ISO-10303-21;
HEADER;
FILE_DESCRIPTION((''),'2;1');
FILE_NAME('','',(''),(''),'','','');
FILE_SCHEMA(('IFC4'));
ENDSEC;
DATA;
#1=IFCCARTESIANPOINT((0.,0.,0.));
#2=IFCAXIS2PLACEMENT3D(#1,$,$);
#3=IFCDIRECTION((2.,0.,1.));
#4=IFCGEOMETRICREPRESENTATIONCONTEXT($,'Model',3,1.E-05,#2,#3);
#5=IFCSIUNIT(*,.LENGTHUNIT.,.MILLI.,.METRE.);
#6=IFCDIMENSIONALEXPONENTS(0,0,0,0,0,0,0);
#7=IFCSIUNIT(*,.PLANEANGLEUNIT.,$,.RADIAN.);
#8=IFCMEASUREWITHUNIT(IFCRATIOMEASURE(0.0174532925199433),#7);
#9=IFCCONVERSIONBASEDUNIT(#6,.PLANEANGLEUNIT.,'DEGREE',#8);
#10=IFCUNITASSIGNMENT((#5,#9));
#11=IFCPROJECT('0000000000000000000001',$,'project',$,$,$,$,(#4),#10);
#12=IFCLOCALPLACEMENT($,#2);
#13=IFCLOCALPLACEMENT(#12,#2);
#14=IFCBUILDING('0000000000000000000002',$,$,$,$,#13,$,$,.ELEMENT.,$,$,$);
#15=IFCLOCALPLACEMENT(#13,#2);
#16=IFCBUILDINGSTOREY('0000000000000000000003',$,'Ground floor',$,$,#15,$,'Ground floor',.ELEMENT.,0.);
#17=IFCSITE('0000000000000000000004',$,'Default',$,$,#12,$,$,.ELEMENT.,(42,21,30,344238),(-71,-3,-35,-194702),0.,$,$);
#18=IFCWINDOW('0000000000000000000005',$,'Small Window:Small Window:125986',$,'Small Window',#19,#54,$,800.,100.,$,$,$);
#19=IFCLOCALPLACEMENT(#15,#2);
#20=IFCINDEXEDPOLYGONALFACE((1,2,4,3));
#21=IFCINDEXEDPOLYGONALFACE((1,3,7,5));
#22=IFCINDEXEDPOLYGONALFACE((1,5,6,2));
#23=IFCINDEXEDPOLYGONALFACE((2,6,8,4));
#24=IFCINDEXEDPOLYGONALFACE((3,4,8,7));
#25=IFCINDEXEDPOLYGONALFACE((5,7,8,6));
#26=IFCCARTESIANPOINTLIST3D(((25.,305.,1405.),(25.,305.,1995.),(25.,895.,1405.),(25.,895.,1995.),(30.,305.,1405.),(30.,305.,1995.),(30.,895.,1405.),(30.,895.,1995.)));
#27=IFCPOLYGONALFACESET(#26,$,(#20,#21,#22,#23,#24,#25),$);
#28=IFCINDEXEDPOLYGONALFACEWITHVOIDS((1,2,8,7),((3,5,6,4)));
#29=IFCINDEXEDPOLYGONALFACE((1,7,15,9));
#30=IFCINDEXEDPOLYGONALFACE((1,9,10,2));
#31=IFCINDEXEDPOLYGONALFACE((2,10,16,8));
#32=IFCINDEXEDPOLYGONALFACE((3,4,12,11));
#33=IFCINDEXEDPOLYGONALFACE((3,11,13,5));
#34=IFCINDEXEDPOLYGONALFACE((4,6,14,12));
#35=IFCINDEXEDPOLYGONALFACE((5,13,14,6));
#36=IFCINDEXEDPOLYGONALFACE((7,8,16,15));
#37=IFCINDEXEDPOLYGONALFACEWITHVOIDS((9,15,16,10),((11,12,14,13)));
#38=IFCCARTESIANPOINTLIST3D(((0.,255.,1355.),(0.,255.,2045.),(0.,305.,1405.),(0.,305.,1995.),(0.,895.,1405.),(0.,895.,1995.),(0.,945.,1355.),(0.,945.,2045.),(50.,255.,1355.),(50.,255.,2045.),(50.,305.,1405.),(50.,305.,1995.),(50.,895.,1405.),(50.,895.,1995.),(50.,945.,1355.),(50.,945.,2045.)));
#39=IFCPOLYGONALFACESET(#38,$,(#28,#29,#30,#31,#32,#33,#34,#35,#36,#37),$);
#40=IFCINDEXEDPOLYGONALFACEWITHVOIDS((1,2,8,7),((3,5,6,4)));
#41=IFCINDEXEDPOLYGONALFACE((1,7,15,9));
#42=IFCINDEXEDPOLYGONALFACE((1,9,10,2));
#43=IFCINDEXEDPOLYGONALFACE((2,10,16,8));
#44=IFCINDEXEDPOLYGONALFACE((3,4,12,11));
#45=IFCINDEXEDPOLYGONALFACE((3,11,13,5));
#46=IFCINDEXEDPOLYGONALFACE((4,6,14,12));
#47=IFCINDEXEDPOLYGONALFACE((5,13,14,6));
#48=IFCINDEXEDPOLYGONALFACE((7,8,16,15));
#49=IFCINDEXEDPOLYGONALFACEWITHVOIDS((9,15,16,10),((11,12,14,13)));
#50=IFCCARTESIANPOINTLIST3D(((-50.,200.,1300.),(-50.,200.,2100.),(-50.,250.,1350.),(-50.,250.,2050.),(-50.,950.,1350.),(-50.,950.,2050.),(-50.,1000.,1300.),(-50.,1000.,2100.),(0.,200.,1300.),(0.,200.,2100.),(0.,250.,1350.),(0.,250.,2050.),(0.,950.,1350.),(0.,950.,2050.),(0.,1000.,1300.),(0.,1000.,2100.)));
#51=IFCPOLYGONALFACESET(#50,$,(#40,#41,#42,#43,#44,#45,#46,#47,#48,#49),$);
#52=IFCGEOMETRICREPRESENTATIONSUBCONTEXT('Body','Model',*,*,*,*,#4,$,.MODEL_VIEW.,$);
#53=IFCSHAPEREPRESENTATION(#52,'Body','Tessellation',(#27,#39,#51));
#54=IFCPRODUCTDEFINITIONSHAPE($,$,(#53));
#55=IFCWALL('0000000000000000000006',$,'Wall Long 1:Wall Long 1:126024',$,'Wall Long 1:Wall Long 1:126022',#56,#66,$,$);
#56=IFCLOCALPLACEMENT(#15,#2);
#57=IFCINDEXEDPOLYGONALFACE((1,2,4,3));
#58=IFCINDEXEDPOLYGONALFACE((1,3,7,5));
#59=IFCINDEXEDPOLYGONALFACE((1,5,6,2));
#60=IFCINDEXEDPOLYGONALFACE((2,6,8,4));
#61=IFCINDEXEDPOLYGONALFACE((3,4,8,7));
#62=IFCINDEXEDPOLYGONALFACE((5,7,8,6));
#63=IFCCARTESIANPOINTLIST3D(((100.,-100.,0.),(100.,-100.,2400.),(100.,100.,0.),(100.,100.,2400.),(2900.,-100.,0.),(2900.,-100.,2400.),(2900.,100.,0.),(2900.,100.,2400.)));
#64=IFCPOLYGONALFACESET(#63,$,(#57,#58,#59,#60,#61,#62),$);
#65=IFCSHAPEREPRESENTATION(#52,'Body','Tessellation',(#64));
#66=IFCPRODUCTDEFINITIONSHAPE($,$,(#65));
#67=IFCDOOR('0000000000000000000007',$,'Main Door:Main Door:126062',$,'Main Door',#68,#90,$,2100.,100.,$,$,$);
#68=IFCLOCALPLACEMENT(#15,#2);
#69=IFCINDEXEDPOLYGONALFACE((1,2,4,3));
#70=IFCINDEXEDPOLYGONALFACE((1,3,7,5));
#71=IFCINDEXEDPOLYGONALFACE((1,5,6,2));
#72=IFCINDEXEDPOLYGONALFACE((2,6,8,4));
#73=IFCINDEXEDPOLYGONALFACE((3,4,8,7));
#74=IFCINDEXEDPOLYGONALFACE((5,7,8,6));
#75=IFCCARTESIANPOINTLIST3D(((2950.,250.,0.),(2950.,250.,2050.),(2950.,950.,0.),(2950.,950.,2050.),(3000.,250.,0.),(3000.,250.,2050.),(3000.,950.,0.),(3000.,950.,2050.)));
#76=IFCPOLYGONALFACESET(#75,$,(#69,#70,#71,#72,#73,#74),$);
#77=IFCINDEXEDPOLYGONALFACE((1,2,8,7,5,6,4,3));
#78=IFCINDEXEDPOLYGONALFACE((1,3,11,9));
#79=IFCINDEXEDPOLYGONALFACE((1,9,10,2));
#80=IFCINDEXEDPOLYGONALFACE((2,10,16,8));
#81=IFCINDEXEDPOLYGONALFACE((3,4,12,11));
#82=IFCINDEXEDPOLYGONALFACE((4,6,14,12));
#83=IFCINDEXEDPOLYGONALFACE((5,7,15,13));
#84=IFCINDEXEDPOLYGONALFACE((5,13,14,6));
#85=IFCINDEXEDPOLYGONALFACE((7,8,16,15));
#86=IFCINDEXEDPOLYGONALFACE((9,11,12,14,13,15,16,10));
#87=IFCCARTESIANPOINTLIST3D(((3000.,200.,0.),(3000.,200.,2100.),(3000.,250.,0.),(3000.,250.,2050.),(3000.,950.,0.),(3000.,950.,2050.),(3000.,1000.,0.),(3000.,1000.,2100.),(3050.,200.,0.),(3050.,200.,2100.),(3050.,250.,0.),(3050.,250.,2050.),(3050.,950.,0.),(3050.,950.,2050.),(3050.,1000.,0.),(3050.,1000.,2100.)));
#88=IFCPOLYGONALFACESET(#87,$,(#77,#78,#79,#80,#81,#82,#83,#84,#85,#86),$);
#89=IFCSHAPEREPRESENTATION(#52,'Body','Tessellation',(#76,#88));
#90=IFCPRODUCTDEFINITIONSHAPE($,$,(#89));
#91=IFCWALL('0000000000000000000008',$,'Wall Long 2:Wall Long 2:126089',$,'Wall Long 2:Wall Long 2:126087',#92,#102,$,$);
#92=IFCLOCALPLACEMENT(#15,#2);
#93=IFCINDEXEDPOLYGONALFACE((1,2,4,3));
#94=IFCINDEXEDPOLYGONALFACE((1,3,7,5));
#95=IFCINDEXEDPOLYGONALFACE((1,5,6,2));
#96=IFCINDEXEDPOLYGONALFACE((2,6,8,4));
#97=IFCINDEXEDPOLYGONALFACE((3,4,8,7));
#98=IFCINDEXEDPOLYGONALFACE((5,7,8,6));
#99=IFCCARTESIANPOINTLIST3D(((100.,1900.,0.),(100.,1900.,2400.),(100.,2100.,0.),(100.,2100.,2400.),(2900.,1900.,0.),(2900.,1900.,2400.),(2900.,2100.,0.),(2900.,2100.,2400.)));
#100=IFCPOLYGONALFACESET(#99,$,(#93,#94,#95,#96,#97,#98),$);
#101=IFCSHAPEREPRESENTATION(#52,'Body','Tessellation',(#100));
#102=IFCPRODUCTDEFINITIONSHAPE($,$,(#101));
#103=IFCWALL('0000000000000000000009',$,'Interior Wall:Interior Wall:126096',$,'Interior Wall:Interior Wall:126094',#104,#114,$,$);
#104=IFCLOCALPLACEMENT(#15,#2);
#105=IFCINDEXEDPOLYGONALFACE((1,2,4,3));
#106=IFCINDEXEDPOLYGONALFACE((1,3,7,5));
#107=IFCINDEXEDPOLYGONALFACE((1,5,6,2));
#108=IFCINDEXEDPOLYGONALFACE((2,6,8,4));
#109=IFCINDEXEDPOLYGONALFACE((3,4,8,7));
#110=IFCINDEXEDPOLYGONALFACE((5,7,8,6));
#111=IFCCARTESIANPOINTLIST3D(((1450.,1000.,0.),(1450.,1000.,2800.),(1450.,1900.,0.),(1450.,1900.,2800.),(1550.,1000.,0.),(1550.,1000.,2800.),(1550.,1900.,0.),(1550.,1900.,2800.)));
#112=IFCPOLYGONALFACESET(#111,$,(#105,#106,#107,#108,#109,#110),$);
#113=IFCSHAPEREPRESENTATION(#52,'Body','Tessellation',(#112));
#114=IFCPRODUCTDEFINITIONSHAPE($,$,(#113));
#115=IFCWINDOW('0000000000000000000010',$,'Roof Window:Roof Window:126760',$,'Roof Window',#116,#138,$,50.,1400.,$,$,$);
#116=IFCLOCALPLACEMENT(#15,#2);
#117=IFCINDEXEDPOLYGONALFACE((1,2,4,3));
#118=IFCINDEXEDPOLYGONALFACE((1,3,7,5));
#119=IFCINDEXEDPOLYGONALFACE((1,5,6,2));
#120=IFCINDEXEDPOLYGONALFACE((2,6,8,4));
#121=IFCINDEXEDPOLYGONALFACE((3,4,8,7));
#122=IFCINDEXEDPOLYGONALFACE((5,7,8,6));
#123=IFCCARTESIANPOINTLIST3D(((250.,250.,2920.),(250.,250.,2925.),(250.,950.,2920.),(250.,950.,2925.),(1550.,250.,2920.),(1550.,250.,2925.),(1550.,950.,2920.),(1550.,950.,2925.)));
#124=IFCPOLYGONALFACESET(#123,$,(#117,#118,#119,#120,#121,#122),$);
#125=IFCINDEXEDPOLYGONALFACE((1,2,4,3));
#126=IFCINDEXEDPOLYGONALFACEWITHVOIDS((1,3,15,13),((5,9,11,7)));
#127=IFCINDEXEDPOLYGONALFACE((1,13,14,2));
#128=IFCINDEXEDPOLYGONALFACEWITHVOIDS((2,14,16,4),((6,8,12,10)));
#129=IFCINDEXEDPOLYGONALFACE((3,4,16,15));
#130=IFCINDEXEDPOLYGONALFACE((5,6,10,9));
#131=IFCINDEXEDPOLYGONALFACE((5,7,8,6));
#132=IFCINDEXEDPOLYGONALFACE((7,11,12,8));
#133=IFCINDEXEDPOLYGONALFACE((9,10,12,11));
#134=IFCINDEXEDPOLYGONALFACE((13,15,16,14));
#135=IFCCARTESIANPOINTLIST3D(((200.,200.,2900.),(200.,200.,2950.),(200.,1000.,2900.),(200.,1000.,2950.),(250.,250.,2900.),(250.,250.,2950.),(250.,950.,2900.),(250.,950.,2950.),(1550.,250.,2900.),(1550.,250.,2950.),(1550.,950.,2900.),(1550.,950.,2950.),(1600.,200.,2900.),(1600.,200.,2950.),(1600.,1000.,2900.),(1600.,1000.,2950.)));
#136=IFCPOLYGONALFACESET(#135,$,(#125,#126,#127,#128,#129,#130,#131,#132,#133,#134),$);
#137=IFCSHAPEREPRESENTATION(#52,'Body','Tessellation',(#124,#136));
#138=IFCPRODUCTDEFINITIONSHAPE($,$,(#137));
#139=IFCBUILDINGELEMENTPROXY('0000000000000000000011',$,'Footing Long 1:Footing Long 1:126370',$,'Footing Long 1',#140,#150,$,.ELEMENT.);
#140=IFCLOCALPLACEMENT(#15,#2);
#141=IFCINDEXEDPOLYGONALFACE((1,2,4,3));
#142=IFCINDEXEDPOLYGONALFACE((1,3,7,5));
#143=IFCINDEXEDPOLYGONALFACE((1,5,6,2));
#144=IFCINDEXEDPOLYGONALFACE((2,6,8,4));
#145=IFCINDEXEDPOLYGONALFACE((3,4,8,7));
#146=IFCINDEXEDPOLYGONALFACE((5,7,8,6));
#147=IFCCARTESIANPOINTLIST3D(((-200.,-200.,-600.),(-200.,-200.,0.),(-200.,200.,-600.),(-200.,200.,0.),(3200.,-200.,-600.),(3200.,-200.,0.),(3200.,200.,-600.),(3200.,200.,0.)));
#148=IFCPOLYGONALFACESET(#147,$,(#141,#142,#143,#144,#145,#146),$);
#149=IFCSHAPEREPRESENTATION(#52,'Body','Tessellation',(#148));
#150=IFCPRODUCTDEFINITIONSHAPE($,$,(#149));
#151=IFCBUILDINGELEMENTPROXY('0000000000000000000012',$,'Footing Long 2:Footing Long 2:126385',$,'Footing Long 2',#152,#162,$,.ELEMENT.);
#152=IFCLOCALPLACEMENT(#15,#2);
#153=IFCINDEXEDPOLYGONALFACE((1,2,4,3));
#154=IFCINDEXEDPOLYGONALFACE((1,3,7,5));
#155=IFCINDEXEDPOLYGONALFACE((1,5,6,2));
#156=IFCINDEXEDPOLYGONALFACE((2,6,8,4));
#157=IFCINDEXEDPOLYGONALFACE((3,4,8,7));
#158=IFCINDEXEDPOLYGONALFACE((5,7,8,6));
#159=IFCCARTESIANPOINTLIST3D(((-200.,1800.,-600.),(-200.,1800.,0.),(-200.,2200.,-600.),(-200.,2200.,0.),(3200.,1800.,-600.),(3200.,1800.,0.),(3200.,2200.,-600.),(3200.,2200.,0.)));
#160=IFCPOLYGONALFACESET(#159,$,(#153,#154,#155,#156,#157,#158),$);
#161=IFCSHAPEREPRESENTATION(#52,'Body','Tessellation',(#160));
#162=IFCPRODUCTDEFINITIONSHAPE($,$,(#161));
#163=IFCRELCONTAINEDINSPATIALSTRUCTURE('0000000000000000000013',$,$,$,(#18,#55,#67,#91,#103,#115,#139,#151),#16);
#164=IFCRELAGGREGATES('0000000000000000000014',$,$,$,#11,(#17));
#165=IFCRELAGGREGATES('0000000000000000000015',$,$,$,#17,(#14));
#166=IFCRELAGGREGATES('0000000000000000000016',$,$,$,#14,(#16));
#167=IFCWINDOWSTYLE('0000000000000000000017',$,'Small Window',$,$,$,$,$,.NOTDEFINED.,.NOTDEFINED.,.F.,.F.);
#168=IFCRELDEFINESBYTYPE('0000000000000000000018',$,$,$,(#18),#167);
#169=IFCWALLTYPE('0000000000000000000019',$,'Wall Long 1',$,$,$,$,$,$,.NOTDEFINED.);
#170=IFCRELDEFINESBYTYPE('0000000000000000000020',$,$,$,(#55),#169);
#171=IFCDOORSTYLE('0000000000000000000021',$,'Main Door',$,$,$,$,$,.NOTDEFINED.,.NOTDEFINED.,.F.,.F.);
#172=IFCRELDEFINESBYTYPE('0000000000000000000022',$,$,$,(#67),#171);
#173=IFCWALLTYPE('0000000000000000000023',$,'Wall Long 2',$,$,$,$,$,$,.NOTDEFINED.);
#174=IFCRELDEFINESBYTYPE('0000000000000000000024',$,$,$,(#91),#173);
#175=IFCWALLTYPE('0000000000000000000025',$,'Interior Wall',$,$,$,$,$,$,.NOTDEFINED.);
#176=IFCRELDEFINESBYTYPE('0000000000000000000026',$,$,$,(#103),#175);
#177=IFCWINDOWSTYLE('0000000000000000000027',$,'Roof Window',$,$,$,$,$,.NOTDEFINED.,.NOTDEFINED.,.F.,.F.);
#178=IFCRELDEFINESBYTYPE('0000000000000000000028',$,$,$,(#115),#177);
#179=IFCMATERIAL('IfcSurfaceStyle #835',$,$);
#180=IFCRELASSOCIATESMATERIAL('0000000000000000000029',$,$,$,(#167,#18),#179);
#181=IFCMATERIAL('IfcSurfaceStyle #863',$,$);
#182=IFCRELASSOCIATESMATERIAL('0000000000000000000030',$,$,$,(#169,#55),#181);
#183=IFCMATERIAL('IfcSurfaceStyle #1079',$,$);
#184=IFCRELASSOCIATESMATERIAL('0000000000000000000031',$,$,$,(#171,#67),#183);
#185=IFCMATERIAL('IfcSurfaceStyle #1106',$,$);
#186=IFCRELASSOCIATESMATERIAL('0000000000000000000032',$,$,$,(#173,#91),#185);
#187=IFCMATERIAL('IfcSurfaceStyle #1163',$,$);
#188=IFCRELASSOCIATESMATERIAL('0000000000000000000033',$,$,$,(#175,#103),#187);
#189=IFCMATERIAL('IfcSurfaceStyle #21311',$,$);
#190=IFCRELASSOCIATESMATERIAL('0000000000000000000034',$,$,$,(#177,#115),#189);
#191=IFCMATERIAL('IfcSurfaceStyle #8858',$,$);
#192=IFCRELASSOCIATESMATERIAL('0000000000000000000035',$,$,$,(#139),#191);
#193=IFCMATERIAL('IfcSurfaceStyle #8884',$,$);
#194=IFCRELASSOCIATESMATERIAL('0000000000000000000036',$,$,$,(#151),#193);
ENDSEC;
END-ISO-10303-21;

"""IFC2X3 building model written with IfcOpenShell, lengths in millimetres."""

from ifc_helpers import new_model, entity, si_unit, converted_unit, direction, frame, frame_2d, origin, origin_2d_with_axis, place, context, subcontext, project, spatial, polyline, rectangle, outline, extrude, source, transform, mapped, material, type_object, type_shapes, element, save


model = new_model("IFC2X3")

# Units and contexts
model_context = context("Model", 3, precision=1e-05, world=origin(), true_north=direction((2.0, 0.0, 1.0)))
body_context = subcontext(model_context, "Body", "Model", "MODEL_VIEW")
ifc_project = project(units=[si_unit("LENGTHUNIT", "METRE", prefix="MILLI"), converted_unit("PLANEANGLEUNIT", "DEGREE", entity("IfcRatioMeasure", 0.0174532925199433), si_unit("PLANEANGLEUNIT", "RADIAN"), dimensions=[0, 0, 0, 0, 0, 0, 0])], contexts=[model_context])

# Site, building, storey
site_placement = place(None, origin())
site = spatial("IfcSite", under=ifc_project, at=site_placement, Name="Default", CompositionType="ELEMENT", RefLatitude=(42, 21, 30, 344238), RefLongitude=(-71, -3, -35, -194702), RefElevation=0.0)
building_placement = place(site_placement, origin())
building = spatial("IfcBuilding", under=site, at=building_placement, CompositionType="ELEMENT")
storey_placement = place(building_placement, origin())
storey = spatial("IfcBuildingStorey", under=building, at=storey_placement, Name="Ground floor", LongName="Ground floor", CompositionType="ELEMENT", Elevation=0.0)

# Window
ifc_material_1 = material(Name="IfcSurfaceStyle #835")
window_style_1 = type_object("IfcWindowStyle", Name="Small Window", ConstructionType="NOTDEFINED", OperationType="NOTDEFINED", ParameterTakesPrecedence=False, Sizeable=False, material=ifc_material_1)
shared_shape_1 = source(origin(), body_context, "Body", "SweptSolid", [
    extrude(rectangle(XDim=5.0, YDim=590.0, at=frame_2d((0.0, 0.0), x_axis=(1.0, 0.0))), frame((27.5, 600.0, 1405.0), z_axis=(0.0, 0.0, 1.0), x_axis=(-1.0, 0.0, 0.0)), (0.0, 0.0, 1.0), 590.0),
    extrude(outline(polyline([(-345.0, -345.0), (345.0, -345.0), (345.0, 345.0), (-345.0, 345.0), (-345.0, -345.0)]), holes=[polyline([(-295.0, 295.0), (295.0, 295.0), (295.0, -295.0), (-295.0, -295.0), (-295.0, 295.0)])]), frame((0.0, 600.0, 1700.0), z_axis=(1.0, 0.0, 0.0), x_axis=(0.0, 1.0, 0.0)), (0.0, 0.0, 1.0), 50.0),
    extrude(outline(polyline([(-400.0, -400.0), (400.0, -400.0), (400.0, 400.0), (-400.0, 400.0), (-400.0, -400.0)]), holes=[polyline([(-350.0, 350.0), (350.0, 350.0), (350.0, -350.0), (-350.0, -350.0), (-350.0, 350.0)])]), frame((-50.0, 600.0, 1700.0), z_axis=(1.0, 0.0, 0.0), x_axis=(0.0, 1.0, 0.0)), (0.0, 0.0, 1.0), 50.0),
])
type_shapes(window_style_1, [shared_shape_1])
window_1_placement = place(building_placement, origin())
element("IfcWindow", 1, at=window_1_placement, inside=storey, type_object=window_style_1, material=ifc_material_1, Name="Small Window:Small Window:125986", ObjectType="Small Window", OverallHeight=800.0, OverallWidth=100.0, context=body_context, shape_type="MappedRepresentation", body=[
    mapped(shared_shape_1, transform((0.0, 0.0, 0.0), scale=1.0)),
])

# Wall
ifc_material_2 = material(Name="IfcSurfaceStyle #863")
wall_type_1 = type_object("IfcWallType", Name="Wall Long 1", PredefinedType="NOTDEFINED", material=ifc_material_2)
wall_1_placement = place(building_placement, frame((100.0, -100.0, 0.0)))
element("IfcWall", 2, at=wall_1_placement, inside=storey, type_object=wall_type_1, material=ifc_material_2, Name="Wall Long 1:Wall Long 1:126024", ObjectType="Wall Long 1:Wall Long 1:126022", context=body_context, shape_type="SweptSolid", body=[
    extrude(rectangle(XDim=200.0, YDim=2800.0, at=origin_2d_with_axis()), frame((1400.0, 100.0, 0.0), z_axis=(0.0, 0.0, 1.0), x_axis=(0.0, 1.0, 0.0)), (0.0, 0.0, 1.0), 2400.0),
])

# Door
ifc_material_3 = material(Name="IfcSurfaceStyle #1079")
door_style_1 = type_object("IfcDoorStyle", Name="Main Door", ConstructionType="NOTDEFINED", OperationType="NOTDEFINED", ParameterTakesPrecedence=False, Sizeable=False, material=ifc_material_3)
shared_shape_2 = source(origin(), body_context, "Body", "SweptSolid", [
    extrude(rectangle(XDim=50.0, YDim=700.0, at=frame_2d((0.0, 0.0), x_axis=(1.0, 0.0))), frame((2975.0, 600.0, 0.0)), (0.0, 0.0, 1.0), 2050.0),
    extrude(outline(polyline([(-400.0, -1062.5), (400.0, -1062.5), (400.0, 1037.5), (350.0, 1037.5), (350.0, -1012.5), (-350.0, -1012.5), (-350.0, 1037.5), (-400.0, 1037.5), (-400.0, -1062.5)])), frame((3000.0, 600.0, 1037.5), z_axis=(1.0, 0.0, 0.0), x_axis=(0.0, -1.0, 0.0)), (0.0, 0.0, 1.0), 50.0),
])
type_shapes(door_style_1, [shared_shape_2])
door_1_placement = place(building_placement, origin())
element("IfcDoor", 3, at=door_1_placement, inside=storey, type_object=door_style_1, material=ifc_material_3, Name="Main Door:Main Door:126062", ObjectType="Main Door", OverallHeight=2100.0, OverallWidth=100.0, context=body_context, shape_type="MappedRepresentation", body=[
    mapped(shared_shape_2, transform((0.0, 0.0, 0.0), scale=1.0)),
])

# Walls
ifc_material_4 = material(Name="IfcSurfaceStyle #1106")
wall_type_2 = type_object("IfcWallType", Name="Wall Long 2", PredefinedType="NOTDEFINED", material=ifc_material_4)
wall_2_placement = place(building_placement, frame((100.0, 1900.0, 0.0)))
element("IfcWall", 4, at=wall_2_placement, inside=storey, type_object=wall_type_2, material=ifc_material_4, Name="Wall Long 2:Wall Long 2:126089", ObjectType="Wall Long 2:Wall Long 2:126087", context=body_context, shape_type="SweptSolid", body=[
    extrude(rectangle(XDim=200.0, YDim=2800.0, at=origin_2d_with_axis()), frame((1400.0, 100.0, 0.0), z_axis=(0.0, 0.0, 1.0), x_axis=(0.0, -1.0, 0.0)), (0.0, 0.0, 1.0), 2400.0),
])
ifc_material_5 = material(Name="IfcSurfaceStyle #1163")
wall_type_3 = type_object("IfcWallType", Name="Interior Wall", PredefinedType="NOTDEFINED", material=ifc_material_5)
wall_3_placement = place(building_placement, frame((1450.0, 1000.0, 0.0), z_axis=(0.0, 0.0, 1.0), x_axis=(0.0, 1.0, 0.0)))
element("IfcWall", 5, at=wall_3_placement, inside=storey, type_object=wall_type_3, material=ifc_material_5, Name="Interior Wall:Interior Wall:126096", ObjectType="Interior Wall:Interior Wall:126094", context=body_context, shape_type="SweptSolid", body=[
    extrude(rectangle(XDim=900.0, YDim=100.0, at=origin_2d_with_axis()), frame((450.0, -50.0, 0.0), z_axis=(0.0, 0.0, 1.0), x_axis=(-1.0, 0.0, 0.0)), (0.0, 0.0, 1.0), 2800.0),
])

# Window
ifc_material_6 = material(Name="IfcSurfaceStyle #21311")
window_style_2 = type_object("IfcWindowStyle", Name="Roof Window", ConstructionType="NOTDEFINED", OperationType="NOTDEFINED", ParameterTakesPrecedence=False, Sizeable=False, material=ifc_material_6)
shared_shape_3 = source(origin(), body_context, "Body", "SweptSolid", [
    extrude(rectangle(XDim=1300.0, YDim=700.0, at=origin_2d_with_axis()), frame((900.0, 600.0, 2920.0), z_axis=(0.0, 0.0, 1.0), x_axis=(-1.0, 0.0, 0.0)), (0.0, 0.0, 1.0), 5.0),
    extrude(outline(polyline([(-700.0, -400.0), (700.0, -400.0), (700.0, 400.0), (-700.0, 400.0), (-700.0, -400.0)]), holes=[polyline([(650.0, -350.0), (-650.0, -350.0), (-650.0, 350.0), (650.0, 350.0), (650.0, -350.0)])]), frame((900.0, 600.0, 2900.0), z_axis=(0.0, 0.0, 1.0), x_axis=(-1.0, 0.0, 0.0)), (0.0, 0.0, 1.0), 50.0),
])
type_shapes(window_style_2, [shared_shape_3])
window_2_placement = place(building_placement, origin())
element("IfcWindow", 6, at=window_2_placement, inside=storey, type_object=window_style_2, material=ifc_material_6, Name="Roof Window:Roof Window:126760", ObjectType="Roof Window", OverallHeight=50.0, OverallWidth=1400.0, context=body_context, shape_type="MappedRepresentation", body=[
    mapped(shared_shape_3, transform((0.0, 0.0, 0.0), scale=1.0)),
])

# Building element proxies
ifc_material_7 = material(Name="IfcSurfaceStyle #8858")
shared_shape_4 = source(origin(), body_context, "Body", "SweptSolid", [
    extrude(rectangle(XDim=3400.0, YDim=400.0, at=origin_2d_with_axis()), frame((1500.0, 0.0, -600.0), z_axis=(0.0, 0.0, 1.0), x_axis=(-1.0, 0.0, 0.0)), (0.0, 0.0, 1.0), 600.0),
])
proxy_1_placement = place(building_placement, origin())
element("IfcBuildingElementProxy", 7, at=proxy_1_placement, inside=storey, material=ifc_material_7, Name="Footing Long 1:Footing Long 1:126370", ObjectType="Footing Long 1", CompositionType="ELEMENT", context=body_context, shape_type="MappedRepresentation", body=[
    mapped(shared_shape_4, transform((0.0, 0.0, 0.0), scale=1.0)),
])
ifc_material_8 = material(Name="IfcSurfaceStyle #8884")
shared_shape_5 = source(origin(), body_context, "Body", "SweptSolid", [
    extrude(rectangle(XDim=3400.0, YDim=400.0, at=origin_2d_with_axis()), frame((1700.0, 200.0, 0.0), z_axis=(0.0, 0.0, 1.0), x_axis=(-1.0, 0.0, 0.0)), (0.0, 0.0, 1.0), 600.0),
])
proxy_2_placement = place(building_placement, frame((-200.0, 1800.0, -600.0)))
element("IfcBuildingElementProxy", 8, at=proxy_2_placement, inside=storey, material=ifc_material_8, Name="Footing Long 2:Footing Long 2:126385", ObjectType="Footing Long 2", CompositionType="ELEMENT", context=body_context, shape_type="MappedRepresentation", body=[
    mapped(shared_shape_5, transform((0.0, 0.0, 0.0), scale=1.0)),
])

save(model, "model.ifc")
